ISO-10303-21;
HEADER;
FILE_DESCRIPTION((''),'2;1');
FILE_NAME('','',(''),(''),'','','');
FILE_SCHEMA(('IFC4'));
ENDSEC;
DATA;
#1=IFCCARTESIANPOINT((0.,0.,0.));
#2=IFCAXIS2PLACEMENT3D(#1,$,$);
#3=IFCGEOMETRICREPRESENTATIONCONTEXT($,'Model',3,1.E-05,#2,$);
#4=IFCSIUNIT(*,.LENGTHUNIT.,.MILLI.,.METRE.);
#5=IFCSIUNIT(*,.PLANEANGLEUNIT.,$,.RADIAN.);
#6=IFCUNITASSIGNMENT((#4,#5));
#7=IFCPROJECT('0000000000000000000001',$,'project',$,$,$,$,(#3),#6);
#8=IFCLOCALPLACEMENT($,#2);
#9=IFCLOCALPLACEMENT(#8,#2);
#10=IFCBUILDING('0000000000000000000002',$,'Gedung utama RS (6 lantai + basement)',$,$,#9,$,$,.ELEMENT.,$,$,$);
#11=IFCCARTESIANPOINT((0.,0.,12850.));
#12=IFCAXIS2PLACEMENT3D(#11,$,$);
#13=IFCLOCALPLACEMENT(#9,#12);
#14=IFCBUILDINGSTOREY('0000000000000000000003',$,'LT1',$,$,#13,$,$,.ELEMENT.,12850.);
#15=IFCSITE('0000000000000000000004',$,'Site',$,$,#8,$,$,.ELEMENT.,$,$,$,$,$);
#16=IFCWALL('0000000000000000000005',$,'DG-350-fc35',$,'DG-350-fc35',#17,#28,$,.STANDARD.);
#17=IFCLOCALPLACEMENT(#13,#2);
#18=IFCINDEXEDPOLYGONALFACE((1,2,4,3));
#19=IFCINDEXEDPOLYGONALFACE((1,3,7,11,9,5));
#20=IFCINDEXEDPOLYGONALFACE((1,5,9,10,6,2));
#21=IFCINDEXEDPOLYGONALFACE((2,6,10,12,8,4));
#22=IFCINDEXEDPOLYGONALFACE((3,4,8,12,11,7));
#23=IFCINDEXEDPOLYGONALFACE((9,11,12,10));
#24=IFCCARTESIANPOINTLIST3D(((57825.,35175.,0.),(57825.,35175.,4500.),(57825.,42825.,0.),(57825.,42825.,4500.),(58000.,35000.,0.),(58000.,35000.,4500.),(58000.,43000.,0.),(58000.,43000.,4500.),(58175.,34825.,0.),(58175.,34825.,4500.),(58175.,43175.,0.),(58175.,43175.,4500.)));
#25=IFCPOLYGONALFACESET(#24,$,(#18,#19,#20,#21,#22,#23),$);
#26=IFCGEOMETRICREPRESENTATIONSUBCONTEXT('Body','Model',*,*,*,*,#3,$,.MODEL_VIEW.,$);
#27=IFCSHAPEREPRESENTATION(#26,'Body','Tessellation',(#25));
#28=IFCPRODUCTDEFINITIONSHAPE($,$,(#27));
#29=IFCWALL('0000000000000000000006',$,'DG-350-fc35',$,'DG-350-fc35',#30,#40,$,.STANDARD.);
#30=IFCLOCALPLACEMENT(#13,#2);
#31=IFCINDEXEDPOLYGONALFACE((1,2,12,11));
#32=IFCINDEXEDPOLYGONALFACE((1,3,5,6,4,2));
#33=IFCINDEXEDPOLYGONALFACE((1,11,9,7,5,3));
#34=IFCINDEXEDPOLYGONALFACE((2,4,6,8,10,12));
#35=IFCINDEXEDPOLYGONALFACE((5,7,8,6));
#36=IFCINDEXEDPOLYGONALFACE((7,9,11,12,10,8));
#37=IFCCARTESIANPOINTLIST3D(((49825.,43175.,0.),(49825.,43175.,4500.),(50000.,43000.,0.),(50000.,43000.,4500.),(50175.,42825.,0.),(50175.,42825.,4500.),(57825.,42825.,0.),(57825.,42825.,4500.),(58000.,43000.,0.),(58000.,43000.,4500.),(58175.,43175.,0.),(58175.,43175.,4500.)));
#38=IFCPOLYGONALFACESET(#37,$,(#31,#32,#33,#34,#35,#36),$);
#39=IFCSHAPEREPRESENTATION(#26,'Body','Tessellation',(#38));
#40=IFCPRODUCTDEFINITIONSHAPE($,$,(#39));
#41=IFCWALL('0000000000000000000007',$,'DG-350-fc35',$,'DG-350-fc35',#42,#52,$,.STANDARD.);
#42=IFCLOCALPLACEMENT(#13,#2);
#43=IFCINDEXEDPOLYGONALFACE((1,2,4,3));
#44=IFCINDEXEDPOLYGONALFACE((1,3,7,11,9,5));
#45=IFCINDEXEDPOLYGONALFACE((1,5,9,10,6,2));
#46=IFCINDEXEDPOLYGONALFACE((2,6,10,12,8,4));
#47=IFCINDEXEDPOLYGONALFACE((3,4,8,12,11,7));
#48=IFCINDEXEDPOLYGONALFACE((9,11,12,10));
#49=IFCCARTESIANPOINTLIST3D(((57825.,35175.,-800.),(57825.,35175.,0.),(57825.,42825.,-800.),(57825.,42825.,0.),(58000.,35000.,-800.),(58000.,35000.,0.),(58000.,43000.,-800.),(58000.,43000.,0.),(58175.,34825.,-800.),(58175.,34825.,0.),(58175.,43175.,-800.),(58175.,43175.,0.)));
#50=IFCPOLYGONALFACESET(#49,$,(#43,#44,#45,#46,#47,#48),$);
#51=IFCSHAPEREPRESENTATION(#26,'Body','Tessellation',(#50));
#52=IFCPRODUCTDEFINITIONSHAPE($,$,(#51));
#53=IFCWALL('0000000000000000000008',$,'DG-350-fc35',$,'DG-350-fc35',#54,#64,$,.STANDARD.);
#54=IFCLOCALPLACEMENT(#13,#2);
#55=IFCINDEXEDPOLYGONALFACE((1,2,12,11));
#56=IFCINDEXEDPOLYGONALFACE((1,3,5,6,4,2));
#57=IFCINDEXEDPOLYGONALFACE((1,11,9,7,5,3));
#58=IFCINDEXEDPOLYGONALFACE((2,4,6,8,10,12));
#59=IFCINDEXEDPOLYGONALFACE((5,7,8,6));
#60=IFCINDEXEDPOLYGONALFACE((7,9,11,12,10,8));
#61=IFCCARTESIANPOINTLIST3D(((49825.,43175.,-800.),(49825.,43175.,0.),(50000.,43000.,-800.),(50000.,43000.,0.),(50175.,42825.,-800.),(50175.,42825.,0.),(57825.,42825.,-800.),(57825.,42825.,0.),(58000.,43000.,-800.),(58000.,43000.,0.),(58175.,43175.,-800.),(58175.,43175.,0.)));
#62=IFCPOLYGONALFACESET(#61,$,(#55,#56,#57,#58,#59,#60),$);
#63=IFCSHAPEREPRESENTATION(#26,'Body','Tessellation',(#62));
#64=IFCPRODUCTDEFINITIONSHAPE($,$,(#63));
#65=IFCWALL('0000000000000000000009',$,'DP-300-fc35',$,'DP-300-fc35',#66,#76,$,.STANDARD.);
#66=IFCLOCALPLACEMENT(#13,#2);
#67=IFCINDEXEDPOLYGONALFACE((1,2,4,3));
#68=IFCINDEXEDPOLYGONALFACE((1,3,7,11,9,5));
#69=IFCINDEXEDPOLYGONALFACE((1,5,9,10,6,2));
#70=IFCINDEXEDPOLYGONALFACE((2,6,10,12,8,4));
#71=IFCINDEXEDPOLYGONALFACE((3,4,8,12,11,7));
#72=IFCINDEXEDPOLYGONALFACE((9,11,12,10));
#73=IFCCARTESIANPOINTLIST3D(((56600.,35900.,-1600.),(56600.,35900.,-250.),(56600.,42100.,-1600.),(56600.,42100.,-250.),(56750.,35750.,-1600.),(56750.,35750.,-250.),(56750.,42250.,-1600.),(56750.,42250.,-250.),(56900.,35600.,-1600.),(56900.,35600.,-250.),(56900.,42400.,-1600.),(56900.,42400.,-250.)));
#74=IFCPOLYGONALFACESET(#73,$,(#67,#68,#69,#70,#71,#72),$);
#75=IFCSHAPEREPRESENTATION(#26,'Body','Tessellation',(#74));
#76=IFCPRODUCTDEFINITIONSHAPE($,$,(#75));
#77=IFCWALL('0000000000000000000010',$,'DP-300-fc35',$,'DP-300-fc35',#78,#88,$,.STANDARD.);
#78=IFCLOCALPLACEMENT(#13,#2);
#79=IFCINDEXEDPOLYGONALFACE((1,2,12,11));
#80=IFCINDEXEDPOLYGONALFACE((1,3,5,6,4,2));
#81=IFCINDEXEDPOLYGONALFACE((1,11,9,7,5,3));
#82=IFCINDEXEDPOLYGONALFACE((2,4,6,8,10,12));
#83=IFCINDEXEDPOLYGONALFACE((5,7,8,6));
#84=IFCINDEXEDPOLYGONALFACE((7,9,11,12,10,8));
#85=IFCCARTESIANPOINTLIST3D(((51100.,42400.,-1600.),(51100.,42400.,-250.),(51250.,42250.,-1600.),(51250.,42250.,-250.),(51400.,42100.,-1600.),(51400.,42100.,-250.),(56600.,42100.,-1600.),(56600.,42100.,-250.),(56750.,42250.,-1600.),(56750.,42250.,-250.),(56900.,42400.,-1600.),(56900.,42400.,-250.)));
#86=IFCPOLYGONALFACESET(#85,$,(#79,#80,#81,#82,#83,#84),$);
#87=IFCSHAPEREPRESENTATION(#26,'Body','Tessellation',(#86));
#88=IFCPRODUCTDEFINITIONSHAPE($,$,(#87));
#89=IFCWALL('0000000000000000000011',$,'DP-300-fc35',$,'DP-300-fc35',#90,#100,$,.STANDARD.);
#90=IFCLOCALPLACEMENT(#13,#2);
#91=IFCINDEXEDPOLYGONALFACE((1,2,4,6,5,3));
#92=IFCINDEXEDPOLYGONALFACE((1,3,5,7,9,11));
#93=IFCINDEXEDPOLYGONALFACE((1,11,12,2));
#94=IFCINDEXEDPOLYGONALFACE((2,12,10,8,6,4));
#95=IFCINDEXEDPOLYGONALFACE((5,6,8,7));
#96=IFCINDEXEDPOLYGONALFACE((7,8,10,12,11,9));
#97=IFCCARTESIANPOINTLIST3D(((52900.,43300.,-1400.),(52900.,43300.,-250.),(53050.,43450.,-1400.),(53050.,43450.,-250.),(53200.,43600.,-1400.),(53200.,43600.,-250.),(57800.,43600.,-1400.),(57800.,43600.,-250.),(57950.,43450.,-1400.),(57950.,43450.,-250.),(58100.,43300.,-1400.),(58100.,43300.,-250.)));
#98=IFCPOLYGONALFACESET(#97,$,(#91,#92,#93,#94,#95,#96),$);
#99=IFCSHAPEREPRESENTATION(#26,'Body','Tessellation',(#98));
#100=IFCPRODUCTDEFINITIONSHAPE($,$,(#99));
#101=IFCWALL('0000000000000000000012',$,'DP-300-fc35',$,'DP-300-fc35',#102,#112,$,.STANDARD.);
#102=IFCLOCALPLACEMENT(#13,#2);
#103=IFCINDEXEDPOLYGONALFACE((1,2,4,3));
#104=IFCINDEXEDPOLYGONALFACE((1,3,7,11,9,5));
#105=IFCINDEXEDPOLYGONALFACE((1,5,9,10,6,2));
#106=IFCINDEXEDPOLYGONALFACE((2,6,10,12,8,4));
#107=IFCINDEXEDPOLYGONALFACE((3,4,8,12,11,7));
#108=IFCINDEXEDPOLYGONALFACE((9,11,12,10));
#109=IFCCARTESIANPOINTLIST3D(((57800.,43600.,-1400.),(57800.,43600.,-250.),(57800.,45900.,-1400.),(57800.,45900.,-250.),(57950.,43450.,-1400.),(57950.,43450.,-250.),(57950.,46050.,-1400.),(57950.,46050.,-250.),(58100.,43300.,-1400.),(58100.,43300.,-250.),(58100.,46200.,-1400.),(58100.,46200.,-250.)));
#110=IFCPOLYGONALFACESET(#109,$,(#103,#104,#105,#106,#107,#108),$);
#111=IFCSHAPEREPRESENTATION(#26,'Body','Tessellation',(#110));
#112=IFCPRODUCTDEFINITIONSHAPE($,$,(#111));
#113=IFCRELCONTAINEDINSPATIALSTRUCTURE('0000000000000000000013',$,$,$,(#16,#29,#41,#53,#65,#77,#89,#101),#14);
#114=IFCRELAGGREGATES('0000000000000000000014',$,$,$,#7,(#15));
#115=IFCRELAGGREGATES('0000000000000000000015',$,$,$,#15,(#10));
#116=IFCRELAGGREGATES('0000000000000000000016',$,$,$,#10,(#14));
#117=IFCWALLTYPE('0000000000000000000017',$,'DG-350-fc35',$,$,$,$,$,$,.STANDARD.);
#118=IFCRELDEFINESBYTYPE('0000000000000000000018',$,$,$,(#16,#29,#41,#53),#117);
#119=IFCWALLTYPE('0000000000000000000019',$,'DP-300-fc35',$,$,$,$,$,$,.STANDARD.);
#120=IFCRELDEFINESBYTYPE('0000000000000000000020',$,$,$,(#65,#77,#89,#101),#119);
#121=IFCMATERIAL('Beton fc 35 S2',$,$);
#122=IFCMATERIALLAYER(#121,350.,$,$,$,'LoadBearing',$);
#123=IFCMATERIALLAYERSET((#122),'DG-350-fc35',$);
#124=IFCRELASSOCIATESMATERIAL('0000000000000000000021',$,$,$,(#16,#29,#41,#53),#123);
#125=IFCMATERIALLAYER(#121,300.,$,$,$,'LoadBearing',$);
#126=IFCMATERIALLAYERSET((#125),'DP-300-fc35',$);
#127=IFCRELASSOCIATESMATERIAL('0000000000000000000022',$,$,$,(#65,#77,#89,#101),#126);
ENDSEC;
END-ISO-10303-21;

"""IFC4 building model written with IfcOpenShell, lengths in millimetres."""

from ifc_helpers import new_model, si_unit, frame, origin, place, context, subcontext, project, spatial, polyline, outline, extrude, material, layer, layer_set, layer_usage, type_object, element, save


model = new_model("IFC4")

# Units and contexts
model_context = context("Model", 3, precision=1e-05, world=origin())
body_context = subcontext(model_context, "Body", "Model", "MODEL_VIEW")
ifc_project = project(units=[si_unit("LENGTHUNIT", "METRE", prefix="MILLI"), si_unit("PLANEANGLEUNIT", "RADIAN")], contexts=[model_context])

# Site, building, storey
site_placement = place(None, origin())
site = spatial("IfcSite", under=ifc_project, at=site_placement, Name="Site", CompositionType="ELEMENT")
building_placement = place(site_placement, origin())
building = spatial("IfcBuilding", under=site, at=building_placement, Name="Gedung utama RS (6 lantai + basement)", CompositionType="ELEMENT")
storey_placement = place(building_placement, frame((0.0, 0.0, 12850.0)))
storey = spatial("IfcBuildingStorey", under=building, at=storey_placement, Name="LT1", CompositionType="ELEMENT", Elevation=12850.0)

# Shared definitions
ifc_material = material(Name="Beton fc 35 S2")

# Walls
ifc_layer_1 = layer(ifc_material, 350.0, Category="LoadBearing")
ifc_layer_set_1 = layer_set([ifc_layer_1], Name="DG-350-fc35")
ifc_layer_usage_1 = layer_usage(ifc_layer_set_1, "AXIS2", "NEGATIVE", 175.0)
wall_type_1 = type_object("IfcWallType", Name="DG-350-fc35", PredefinedType="STANDARD")
for number, where, z_axis, x_axis, name in (
    (1, (58000.0, 35000.0, 0.0), (0.0, 0.0, 1.0), (0.0, 1.0, 0.0), "DG-350-fc35"),
    (2, (58000.0, 43000.0, 0.0), (0.0, 0.0, 1.0), (-1.0, 0.0, 0.0), "DG-350-fc35"),
):
    element("IfcWall", number, at=place(storey_placement, frame(where, z_axis=z_axis, x_axis=x_axis)), inside=storey, type_object=wall_type_1, material=ifc_layer_usage_1, Name=name, ObjectType="DG-350-fc35", PredefinedType="STANDARD", context=body_context, shape_type="SweptSolid", body=[
        extrude(outline(polyline([(-175.0, -175.0), (0.0, 0.0), (175.0, 175.0), (7825.0, 175.0), (8000.0, 0.0), (8175.0, -175.0), (-175.0, -175.0)])), origin(), (0.0, 0.0, 1.0), 4500.0),
    ])
for number, where, z_axis, x_axis, name in (
    (3, (58000.0, 35000.0, -800.0), (0.0, 0.0, 1.0), (0.0, 1.0, 0.0), "DG-350-fc35"),
    (4, (58000.0, 43000.0, -800.0), (0.0, 0.0, 1.0), (-1.0, 0.0, 0.0), "DG-350-fc35"),
):
    element("IfcWall", number, at=place(storey_placement, frame(where, z_axis=z_axis, x_axis=x_axis)), inside=storey, type_object=wall_type_1, material=ifc_layer_usage_1, Name=name, ObjectType="DG-350-fc35", PredefinedType="STANDARD", context=body_context, shape_type="SweptSolid", body=[
        extrude(outline(polyline([(-175.0, -175.0), (0.0, 0.0), (175.0, 175.0), (7825.0, 175.0), (8000.0, 0.0), (8175.0, -175.0), (-175.0, -175.0)])), origin(), (0.0, 0.0, 1.0), 800.0),
    ])
ifc_layer_2 = layer(ifc_material, 300.0, Category="LoadBearing")
ifc_layer_set_2 = layer_set([ifc_layer_2], Name="DP-300-fc35")
ifc_layer_usage_2 = layer_usage(ifc_layer_set_2, "AXIS2", "NEGATIVE", 150.0)
wall_type_2 = type_object("IfcWallType", Name="DP-300-fc35", PredefinedType="STANDARD")
wall_1_placement = place(storey_placement, frame((56750.0, 35750.0, -1600.0), z_axis=(0.0, 0.0, 1.0), x_axis=(0.0, 1.0, 0.0)))
element("IfcWall", 5, at=wall_1_placement, inside=storey, type_object=wall_type_2, material=ifc_layer_usage_2, Name="DP-300-fc35", ObjectType="DP-300-fc35", PredefinedType="STANDARD", context=body_context, shape_type="SweptSolid", body=[
    extrude(outline(polyline([(-150.0, -150.0), (0.0, 0.0), (150.0, 150.0), (6350.0, 150.0), (6500.0, 0.0), (6650.0, -150.0), (-150.0, -150.0)])), origin(), (0.0, 0.0, 1.0), 1350.0),
])
wall_2_placement = place(storey_placement, frame((56750.0, 42250.0, -1600.0), z_axis=(0.0, 0.0, 1.0), x_axis=(-1.0, 0.0, 0.0)))
element("IfcWall", 6, at=wall_2_placement, inside=storey, type_object=wall_type_2, material=ifc_layer_usage_2, Name="DP-300-fc35", ObjectType="DP-300-fc35", PredefinedType="STANDARD", context=body_context, shape_type="SweptSolid", body=[
    extrude(outline(polyline([(-150.0, -150.0), (0.0, 0.0), (150.0, 150.0), (5350.0, 150.0), (5500.0, 0.0), (5650.0, -150.0), (-150.0, -150.0)])), origin(), (0.0, 0.0, 1.0), 1350.0),
])
wall_3_placement = place(storey_placement, frame((53050.0, 43450.0, -1400.0), z_axis=(0.0, 0.0, 1.0), x_axis=(1.0, 0.0, 0.0)))
element("IfcWall", 7, at=wall_3_placement, inside=storey, type_object=wall_type_2, material=ifc_layer_usage_2, Name="DP-300-fc35", ObjectType="DP-300-fc35", PredefinedType="STANDARD", context=body_context, shape_type="SweptSolid", body=[
    extrude(outline(polyline([(-150.0, -150.0), (0.0, 0.0), (150.0, 150.0), (4750.0, 150.0), (4900.0, 0.0), (5050.0, -150.0), (-150.0, -150.0)])), origin(), (0.0, 0.0, 1.0), 1150.0),
])
wall_4_placement = place(storey_placement, frame((57950.0, 43450.0, -1400.0), z_axis=(0.0, 0.0, 1.0), x_axis=(0.0, 1.0, 0.0)))
element("IfcWall", 8, at=wall_4_placement, inside=storey, type_object=wall_type_2, material=ifc_layer_usage_2, Name="DP-300-fc35", ObjectType="DP-300-fc35", PredefinedType="STANDARD", context=body_context, shape_type="SweptSolid", body=[
    extrude(outline(polyline([(-150.0, -150.0), (0.0, 0.0), (150.0, 150.0), (2450.0, 150.0), (2600.0, 0.0), (2750.0, -150.0), (-150.0, -150.0)])), origin(), (0.0, 0.0, 1.0), 1150.0),
])

save(model, "model.ifc")
